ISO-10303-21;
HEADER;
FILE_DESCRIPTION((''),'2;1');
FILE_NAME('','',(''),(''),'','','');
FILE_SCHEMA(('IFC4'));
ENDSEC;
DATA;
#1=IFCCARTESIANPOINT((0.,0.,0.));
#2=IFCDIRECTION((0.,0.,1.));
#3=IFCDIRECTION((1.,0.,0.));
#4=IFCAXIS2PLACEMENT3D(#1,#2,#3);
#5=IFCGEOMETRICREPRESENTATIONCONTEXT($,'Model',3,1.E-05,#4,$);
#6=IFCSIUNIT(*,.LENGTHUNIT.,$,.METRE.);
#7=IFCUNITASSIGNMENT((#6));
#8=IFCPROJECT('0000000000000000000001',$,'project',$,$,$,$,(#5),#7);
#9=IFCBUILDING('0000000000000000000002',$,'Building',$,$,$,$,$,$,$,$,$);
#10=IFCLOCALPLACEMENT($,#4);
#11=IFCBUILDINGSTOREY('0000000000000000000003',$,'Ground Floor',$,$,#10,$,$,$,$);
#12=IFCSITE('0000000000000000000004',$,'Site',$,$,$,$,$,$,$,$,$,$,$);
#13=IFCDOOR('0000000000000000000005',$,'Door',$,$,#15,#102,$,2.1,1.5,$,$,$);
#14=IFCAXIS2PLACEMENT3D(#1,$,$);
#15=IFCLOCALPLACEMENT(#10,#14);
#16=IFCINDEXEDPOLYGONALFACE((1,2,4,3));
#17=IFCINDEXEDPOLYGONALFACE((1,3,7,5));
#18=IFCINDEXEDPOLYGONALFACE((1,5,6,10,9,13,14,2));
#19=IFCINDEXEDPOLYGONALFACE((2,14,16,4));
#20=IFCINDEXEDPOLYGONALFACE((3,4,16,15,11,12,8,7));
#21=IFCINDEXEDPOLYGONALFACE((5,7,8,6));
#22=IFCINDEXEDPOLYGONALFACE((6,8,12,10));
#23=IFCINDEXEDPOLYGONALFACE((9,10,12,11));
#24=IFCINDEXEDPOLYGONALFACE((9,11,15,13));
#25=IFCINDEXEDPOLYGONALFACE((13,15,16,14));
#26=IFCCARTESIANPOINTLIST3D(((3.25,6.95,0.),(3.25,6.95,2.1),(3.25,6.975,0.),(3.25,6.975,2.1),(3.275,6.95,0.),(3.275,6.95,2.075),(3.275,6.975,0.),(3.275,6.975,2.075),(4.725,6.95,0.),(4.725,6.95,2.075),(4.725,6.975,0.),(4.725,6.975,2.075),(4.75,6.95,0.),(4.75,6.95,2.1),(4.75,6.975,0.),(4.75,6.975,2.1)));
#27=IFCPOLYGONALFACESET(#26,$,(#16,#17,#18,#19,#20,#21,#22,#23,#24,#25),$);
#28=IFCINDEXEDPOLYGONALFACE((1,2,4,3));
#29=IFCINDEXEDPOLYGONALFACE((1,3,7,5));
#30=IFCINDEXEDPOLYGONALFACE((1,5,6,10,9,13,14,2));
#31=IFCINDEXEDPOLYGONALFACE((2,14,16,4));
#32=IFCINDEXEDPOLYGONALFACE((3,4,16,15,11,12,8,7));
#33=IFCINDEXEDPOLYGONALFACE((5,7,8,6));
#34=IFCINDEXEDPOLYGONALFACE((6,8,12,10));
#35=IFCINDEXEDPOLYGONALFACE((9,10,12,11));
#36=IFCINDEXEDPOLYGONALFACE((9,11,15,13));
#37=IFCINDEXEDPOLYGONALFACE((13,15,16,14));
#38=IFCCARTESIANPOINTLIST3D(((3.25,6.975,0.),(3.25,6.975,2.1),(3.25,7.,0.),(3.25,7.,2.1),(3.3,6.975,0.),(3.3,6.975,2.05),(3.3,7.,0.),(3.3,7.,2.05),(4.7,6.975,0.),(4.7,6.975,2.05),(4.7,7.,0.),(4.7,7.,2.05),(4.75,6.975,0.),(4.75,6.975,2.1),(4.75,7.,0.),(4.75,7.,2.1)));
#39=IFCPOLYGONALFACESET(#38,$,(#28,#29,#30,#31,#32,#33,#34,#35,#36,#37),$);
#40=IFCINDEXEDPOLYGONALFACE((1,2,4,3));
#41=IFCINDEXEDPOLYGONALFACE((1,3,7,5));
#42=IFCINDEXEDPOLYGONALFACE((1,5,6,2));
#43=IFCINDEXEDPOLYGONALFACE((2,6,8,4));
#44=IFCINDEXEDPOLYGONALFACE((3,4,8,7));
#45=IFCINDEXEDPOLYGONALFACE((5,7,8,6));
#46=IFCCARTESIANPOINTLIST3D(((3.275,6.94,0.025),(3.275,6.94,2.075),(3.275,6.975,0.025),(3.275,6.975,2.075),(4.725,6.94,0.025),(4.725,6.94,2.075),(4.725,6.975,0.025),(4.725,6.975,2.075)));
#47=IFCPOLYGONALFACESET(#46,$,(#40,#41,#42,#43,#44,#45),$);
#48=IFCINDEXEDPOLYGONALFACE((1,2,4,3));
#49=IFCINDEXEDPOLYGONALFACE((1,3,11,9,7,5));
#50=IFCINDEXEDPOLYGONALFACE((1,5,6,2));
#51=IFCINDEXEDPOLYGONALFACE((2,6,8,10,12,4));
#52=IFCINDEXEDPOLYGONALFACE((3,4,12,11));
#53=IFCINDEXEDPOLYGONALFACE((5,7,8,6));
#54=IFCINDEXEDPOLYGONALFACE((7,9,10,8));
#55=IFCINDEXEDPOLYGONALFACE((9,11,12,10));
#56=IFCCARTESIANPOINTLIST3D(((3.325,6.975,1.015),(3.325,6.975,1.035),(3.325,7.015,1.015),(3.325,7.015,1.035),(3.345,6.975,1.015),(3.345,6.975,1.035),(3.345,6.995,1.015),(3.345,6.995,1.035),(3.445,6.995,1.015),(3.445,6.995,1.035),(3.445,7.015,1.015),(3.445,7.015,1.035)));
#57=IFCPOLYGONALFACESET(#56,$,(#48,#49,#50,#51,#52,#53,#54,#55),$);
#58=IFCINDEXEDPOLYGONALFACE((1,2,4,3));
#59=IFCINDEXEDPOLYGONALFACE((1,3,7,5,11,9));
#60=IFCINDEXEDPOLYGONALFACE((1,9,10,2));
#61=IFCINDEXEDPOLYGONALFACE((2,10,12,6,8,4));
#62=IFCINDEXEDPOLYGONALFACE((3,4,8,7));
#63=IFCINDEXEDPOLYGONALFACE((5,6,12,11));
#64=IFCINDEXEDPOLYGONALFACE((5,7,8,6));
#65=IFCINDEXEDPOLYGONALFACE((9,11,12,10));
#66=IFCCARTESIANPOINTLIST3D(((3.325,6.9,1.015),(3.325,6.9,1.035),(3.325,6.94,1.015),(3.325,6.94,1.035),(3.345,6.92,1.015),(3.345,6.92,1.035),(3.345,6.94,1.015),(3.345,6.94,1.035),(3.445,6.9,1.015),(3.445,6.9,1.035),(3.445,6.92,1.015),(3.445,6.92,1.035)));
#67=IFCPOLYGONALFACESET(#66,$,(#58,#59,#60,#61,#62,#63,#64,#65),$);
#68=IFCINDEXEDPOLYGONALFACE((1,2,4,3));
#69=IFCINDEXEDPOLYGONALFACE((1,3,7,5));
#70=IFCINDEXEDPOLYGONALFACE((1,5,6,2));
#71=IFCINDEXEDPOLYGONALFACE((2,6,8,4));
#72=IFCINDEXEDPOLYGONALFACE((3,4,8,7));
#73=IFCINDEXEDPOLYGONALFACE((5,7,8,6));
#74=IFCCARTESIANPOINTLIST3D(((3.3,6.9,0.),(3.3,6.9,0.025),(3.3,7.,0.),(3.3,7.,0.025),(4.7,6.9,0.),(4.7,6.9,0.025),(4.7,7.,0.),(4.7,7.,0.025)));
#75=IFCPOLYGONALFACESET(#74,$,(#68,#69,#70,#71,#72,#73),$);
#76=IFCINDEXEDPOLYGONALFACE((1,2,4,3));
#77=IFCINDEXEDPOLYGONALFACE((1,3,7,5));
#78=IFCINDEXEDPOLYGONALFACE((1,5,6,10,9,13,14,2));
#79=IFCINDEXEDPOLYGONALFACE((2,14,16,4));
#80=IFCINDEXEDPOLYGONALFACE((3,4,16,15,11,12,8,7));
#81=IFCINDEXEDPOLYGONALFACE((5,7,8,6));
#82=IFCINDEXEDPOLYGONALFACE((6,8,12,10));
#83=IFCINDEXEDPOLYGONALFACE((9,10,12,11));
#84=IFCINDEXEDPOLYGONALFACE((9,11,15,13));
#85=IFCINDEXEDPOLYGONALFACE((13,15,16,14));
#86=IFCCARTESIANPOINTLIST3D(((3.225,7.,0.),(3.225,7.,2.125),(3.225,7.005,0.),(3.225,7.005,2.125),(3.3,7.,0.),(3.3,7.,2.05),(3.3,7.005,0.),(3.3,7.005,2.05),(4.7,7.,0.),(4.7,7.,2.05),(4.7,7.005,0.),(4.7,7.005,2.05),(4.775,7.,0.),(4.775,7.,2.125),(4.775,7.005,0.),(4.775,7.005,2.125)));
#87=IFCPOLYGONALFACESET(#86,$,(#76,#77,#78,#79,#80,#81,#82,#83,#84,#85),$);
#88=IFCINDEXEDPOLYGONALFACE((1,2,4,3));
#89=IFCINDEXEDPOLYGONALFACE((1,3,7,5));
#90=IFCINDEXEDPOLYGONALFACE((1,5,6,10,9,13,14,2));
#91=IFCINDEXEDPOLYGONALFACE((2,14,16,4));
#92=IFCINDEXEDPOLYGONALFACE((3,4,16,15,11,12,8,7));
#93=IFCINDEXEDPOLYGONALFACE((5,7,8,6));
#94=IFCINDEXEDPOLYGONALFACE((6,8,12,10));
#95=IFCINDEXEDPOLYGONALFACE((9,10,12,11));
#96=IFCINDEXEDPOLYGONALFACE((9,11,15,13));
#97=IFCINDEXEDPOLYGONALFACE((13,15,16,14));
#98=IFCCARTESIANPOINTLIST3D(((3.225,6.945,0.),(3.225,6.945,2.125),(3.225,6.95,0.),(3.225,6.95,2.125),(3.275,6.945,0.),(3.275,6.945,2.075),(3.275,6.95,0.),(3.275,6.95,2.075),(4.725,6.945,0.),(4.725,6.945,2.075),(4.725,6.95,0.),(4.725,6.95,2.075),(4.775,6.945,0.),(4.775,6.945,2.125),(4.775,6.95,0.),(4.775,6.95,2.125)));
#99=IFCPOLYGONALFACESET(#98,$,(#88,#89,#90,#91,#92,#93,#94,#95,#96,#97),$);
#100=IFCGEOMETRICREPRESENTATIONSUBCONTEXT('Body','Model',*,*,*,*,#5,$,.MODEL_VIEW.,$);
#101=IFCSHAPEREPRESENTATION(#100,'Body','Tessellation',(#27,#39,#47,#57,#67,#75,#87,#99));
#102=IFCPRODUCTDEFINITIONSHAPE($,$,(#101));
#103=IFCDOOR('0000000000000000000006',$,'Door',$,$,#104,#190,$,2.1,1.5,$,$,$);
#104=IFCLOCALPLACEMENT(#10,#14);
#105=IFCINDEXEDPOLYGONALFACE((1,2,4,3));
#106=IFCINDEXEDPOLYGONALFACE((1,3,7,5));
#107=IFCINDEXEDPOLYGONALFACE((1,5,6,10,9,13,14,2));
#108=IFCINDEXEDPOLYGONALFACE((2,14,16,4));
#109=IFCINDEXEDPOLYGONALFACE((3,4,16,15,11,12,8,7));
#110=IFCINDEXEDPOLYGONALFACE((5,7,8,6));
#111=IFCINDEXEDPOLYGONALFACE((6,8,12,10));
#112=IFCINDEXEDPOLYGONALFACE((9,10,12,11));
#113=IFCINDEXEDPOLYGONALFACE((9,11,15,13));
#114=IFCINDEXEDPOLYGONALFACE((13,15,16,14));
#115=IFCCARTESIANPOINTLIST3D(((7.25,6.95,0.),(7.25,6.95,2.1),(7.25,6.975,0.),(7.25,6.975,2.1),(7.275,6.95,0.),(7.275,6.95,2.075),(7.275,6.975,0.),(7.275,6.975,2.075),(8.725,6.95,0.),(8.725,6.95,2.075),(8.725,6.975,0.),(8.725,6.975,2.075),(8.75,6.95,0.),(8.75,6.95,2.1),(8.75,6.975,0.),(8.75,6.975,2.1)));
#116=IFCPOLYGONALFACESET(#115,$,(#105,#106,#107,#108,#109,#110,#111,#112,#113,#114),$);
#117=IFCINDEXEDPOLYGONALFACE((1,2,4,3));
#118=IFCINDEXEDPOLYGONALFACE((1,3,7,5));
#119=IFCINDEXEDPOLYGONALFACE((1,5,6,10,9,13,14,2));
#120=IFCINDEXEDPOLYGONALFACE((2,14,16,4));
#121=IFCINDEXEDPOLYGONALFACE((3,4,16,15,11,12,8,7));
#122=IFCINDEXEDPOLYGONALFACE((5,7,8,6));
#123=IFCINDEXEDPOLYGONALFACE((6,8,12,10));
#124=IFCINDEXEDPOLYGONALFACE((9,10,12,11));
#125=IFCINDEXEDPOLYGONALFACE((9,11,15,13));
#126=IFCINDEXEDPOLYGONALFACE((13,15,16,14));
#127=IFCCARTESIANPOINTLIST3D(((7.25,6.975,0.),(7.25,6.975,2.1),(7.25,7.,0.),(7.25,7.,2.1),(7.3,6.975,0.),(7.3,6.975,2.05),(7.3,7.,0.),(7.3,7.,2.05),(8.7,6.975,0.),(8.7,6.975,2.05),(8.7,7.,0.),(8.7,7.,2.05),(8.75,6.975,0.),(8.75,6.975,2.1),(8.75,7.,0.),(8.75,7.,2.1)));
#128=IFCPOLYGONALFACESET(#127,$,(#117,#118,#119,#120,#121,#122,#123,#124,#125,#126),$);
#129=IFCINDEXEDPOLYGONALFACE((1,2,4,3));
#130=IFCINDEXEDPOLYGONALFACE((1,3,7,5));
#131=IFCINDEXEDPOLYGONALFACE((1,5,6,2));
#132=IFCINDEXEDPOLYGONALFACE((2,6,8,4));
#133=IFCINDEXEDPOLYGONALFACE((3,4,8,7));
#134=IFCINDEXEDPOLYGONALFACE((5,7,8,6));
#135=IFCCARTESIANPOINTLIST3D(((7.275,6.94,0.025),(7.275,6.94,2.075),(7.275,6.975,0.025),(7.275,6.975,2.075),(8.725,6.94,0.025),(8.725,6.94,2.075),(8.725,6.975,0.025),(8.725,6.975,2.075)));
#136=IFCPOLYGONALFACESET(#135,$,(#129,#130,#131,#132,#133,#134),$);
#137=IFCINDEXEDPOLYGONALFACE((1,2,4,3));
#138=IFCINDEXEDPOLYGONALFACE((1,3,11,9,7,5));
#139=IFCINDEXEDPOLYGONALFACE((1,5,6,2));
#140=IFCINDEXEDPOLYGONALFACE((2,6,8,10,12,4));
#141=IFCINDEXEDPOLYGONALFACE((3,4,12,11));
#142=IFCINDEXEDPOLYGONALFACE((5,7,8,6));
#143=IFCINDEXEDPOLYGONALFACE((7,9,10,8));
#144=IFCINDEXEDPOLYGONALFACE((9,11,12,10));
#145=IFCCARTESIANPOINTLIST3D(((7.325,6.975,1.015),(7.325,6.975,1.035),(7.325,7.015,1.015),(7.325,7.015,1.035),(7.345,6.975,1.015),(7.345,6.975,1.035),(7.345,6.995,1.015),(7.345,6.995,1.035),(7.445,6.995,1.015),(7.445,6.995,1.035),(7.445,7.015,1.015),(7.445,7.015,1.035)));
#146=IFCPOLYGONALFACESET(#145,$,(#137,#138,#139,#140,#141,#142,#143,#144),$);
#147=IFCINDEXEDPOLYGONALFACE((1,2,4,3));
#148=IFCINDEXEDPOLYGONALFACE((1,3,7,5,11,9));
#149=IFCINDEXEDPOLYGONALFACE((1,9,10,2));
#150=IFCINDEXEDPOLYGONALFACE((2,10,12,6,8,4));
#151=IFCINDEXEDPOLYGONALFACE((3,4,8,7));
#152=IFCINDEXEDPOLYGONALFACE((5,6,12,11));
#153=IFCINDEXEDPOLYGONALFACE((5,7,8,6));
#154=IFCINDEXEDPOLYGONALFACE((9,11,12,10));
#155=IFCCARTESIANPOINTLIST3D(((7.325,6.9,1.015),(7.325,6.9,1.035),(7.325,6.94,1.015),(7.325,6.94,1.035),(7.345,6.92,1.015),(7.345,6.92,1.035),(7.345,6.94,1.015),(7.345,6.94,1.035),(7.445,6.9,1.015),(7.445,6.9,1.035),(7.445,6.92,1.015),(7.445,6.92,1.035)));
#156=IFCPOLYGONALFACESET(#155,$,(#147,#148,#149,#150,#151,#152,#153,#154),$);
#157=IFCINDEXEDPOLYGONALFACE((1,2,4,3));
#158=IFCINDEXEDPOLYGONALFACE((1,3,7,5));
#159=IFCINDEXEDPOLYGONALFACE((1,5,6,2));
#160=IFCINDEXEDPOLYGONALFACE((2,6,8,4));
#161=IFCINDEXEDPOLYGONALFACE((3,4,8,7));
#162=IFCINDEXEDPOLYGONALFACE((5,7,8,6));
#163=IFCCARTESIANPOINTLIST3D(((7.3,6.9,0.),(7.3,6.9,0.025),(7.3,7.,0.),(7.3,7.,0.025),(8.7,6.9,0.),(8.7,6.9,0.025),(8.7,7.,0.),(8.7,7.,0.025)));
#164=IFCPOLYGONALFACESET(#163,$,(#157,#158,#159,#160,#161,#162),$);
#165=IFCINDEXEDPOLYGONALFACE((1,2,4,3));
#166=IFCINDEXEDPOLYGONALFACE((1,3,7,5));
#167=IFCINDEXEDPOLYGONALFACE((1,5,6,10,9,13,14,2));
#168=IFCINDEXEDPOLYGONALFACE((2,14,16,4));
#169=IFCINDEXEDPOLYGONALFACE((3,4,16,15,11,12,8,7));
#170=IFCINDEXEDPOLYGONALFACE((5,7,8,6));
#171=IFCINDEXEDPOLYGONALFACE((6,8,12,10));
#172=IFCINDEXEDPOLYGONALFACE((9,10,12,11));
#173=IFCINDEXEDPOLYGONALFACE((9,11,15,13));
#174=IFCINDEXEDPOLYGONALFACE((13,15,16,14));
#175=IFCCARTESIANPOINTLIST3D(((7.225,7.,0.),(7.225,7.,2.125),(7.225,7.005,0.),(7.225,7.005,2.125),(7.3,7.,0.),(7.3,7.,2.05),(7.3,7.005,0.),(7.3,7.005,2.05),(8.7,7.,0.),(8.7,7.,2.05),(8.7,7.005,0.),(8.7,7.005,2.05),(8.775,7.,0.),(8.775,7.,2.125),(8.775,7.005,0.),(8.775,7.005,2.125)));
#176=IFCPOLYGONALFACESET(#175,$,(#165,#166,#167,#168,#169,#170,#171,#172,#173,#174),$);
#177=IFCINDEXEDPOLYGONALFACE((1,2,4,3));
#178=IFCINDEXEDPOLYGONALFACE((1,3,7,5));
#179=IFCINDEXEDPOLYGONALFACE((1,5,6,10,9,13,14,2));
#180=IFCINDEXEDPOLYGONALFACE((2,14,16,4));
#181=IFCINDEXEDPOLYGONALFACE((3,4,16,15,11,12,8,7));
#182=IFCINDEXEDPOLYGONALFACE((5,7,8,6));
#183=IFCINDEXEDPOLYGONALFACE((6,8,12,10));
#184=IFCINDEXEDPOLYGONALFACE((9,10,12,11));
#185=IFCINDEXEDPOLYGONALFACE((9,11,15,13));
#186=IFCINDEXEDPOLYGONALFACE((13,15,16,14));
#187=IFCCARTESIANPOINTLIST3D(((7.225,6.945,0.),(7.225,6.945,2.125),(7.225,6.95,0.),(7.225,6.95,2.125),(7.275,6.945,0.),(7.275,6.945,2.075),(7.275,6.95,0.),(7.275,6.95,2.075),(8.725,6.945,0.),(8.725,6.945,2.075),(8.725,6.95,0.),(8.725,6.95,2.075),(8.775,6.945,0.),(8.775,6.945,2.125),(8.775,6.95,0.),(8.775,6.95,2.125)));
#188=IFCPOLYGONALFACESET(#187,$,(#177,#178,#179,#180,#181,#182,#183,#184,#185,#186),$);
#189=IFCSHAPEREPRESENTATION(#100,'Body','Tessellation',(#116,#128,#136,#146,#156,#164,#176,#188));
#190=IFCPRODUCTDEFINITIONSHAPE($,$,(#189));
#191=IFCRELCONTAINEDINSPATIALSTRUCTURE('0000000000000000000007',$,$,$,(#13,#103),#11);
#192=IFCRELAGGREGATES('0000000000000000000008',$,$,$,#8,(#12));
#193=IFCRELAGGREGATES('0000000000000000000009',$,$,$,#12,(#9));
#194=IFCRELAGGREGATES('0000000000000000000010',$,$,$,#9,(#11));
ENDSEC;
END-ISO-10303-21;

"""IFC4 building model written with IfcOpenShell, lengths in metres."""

from ifc_helpers import new_model, si_unit, frame, origin_with_axes, place, context, subcontext, project, spatial, line, indexed_curve, outline, extrude, element, save


model = new_model("IFC4")

# Units and contexts
model_context = context("Model", 3, precision=1e-05, world=origin_with_axes())
body_context = subcontext(model_context, "Body", "Model", "MODEL_VIEW")
ifc_project = project(units=[si_unit("LENGTHUNIT", "METRE")], contexts=[model_context])

# Site, building, storey
site = spatial("IfcSite", under=ifc_project, Name="Site")
building = spatial("IfcBuilding", under=site, Name="Building")
storey_placement = place(None, origin_with_axes())
storey = spatial("IfcBuildingStorey", under=building, at=storey_placement, Name="Ground Floor")

# Doors
door_1_placement = place(storey_placement, frame((4.75, 7.0, 0.0), z_axis=(0.0, 0.0, 1.0), x_axis=(-1.0, 0.0, 0.0)))
element("IfcDoor", 1, at=door_1_placement, inside=storey, Name="Door", OverallHeight=2.1, OverallWidth=1.5, context=body_context, shape_type="SweptSolid", body=[
    extrude(outline(indexed_curve([(0.0, 0.0), (0.0, 2.1), (1.5, 2.1), (1.5, 0.0), (1.475, 0.0), (1.475, 2.075), (0.025, 2.075), (0.025, 0.0)], segments=[line(1, 2, 3, 4, 5, 6, 7, 8, 1)])), frame((0.0, 0.025, 0.0), z_axis=(0.0, -1.0, 0.0), x_axis=(1.0, 0.0, 0.0)), (0.0, 0.0, -1.0), 0.025),
    extrude(outline(indexed_curve([(0.0, 0.0), (0.0, 2.1), (1.5, 2.1), (1.5, 0.0), (1.45, 0.0), (1.45, 2.05), (0.05, 2.05), (0.05, 0.0)], segments=[line(1, 2, 3, 4, 5, 6, 7, 8, 1)])), frame((0.0, 0.0, 0.0), z_axis=(0.0, -1.0, 0.0), x_axis=(1.0, 0.0, 0.0)), (0.0, 0.0, -1.0), 0.025),
    extrude(outline(indexed_curve([(0.0, 0.0), (1.45, 0.0), (1.45, 0.035), (0.0, 0.035)], segments=[line(1, 2, 3, 4, 1)])), frame((0.025, 0.025, 0.025), z_axis=(0.0, 0.0, 1.0), x_axis=(1.0, 0.0, 0.0)), (0.0, 0.0, 1.0), 2.05),
    extrude(outline(indexed_curve([(0.0, 0.0), (0.0, -0.04), (-0.12, -0.04), (-0.12, -0.02), (-0.02, -0.02), (-0.02, 0.0)], segments=[line(1, 2, 3, 4, 5, 6, 1)])), frame((1.425, 0.025, 1.015), z_axis=(0.0, 0.0, 1.0), x_axis=(1.0, 0.0, 0.0)), (0.0, 0.0, 1.0), 0.02),
    extrude(outline(indexed_curve([(0.0, 0.0), (0.0, 0.04), (-0.12, 0.04), (-0.12, 0.02), (-0.02, 0.02), (-0.02, 0.0)], segments=[line(1, 2, 3, 4, 5, 6, 1)])), frame((1.425, 0.06, 1.015), z_axis=(0.0, 0.0, 1.0), x_axis=(1.0, 0.0, 0.0)), (0.0, 0.0, 1.0), 0.02),
    extrude(outline(indexed_curve([(0.0, 0.0), (1.4, 0.0), (1.4, 0.1), (0.0, 0.1)], segments=[line(1, 2, 3, 4, 1)])), frame((0.05, 0.0, 0.0), z_axis=(0.0, 0.0, 1.0), x_axis=(1.0, 0.0, 0.0)), (0.0, 0.0, 1.0), 0.025),
    extrude(outline(indexed_curve([(0.0, 0.0), (0.0, 2.125), (1.55, 2.125), (1.55, 0.0), (1.475, 0.0), (1.475, 2.05), (0.075, 2.05), (0.075, 0.0)], segments=[line(1, 2, 3, 4, 5, 6, 7, 8, 1)])), frame((-0.025, -0.005, 0.0), z_axis=(0.0, -1.0, 0.0), x_axis=(1.0, 0.0, 0.0)), (0.0, 0.0, -1.0), 0.005),
    extrude(outline(indexed_curve([(0.0, 0.0), (0.0, 2.125), (1.55, 2.125), (1.55, 0.0), (1.5, 0.0), (1.5, 2.075), (0.05, 2.075), (0.05, 0.0)], segments=[line(1, 2, 3, 4, 5, 6, 7, 8, 1)])), frame((-0.025, 0.05, 0.0), z_axis=(0.0, -1.0, 0.0), x_axis=(1.0, 0.0, 0.0)), (0.0, 0.0, -1.0), 0.005),
])
door_2_placement = place(storey_placement, frame((8.75, 7.0, 0.0), z_axis=(0.0, 0.0, 1.0), x_axis=(-1.0, 0.0, 0.0)))
element("IfcDoor", 2, at=door_2_placement, inside=storey, Name="Door", OverallHeight=2.1, OverallWidth=1.5, context=body_context, shape_type="SweptSolid", body=[
    extrude(outline(indexed_curve([(0.0, 0.0), (0.0, 2.1), (1.5, 2.1), (1.5, 0.0), (1.475, 0.0), (1.475, 2.075), (0.025, 2.075), (0.025, 0.0)], segments=[line(1, 2, 3, 4, 5, 6, 7, 8, 1)])), frame((0.0, 0.025, 0.0), z_axis=(0.0, -1.0, 0.0), x_axis=(1.0, 0.0, 0.0)), (0.0, 0.0, -1.0), 0.025),
    extrude(outline(indexed_curve([(0.0, 0.0), (0.0, 2.1), (1.5, 2.1), (1.5, 0.0), (1.45, 0.0), (1.45, 2.05), (0.05, 2.05), (0.05, 0.0)], segments=[line(1, 2, 3, 4, 5, 6, 7, 8, 1)])), frame((0.0, 0.0, 0.0), z_axis=(0.0, -1.0, 0.0), x_axis=(1.0, 0.0, 0.0)), (0.0, 0.0, -1.0), 0.025),
    extrude(outline(indexed_curve([(0.0, 0.0), (1.45, 0.0), (1.45, 0.035), (0.0, 0.035)], segments=[line(1, 2, 3, 4, 1)])), frame((0.025, 0.025, 0.025), z_axis=(0.0, 0.0, 1.0), x_axis=(1.0, 0.0, 0.0)), (0.0, 0.0, 1.0), 2.05),
    extrude(outline(indexed_curve([(0.0, 0.0), (0.0, -0.04), (-0.12, -0.04), (-0.12, -0.02), (-0.02, -0.02), (-0.02, 0.0)], segments=[line(1, 2, 3, 4, 5, 6, 1)])), frame((1.425, 0.025, 1.015), z_axis=(0.0, 0.0, 1.0), x_axis=(1.0, 0.0, 0.0)), (0.0, 0.0, 1.0), 0.02),
    extrude(outline(indexed_curve([(0.0, 0.0), (0.0, 0.04), (-0.12, 0.04), (-0.12, 0.02), (-0.02, 0.02), (-0.02, 0.0)], segments=[line(1, 2, 3, 4, 5, 6, 1)])), frame((1.425, 0.06, 1.015), z_axis=(0.0, 0.0, 1.0), x_axis=(1.0, 0.0, 0.0)), (0.0, 0.0, 1.0), 0.02),
    extrude(outline(indexed_curve([(0.0, 0.0), (1.4, 0.0), (1.4, 0.1), (0.0, 0.1)], segments=[line(1, 2, 3, 4, 1)])), frame((0.05, 0.0, 0.0), z_axis=(0.0, 0.0, 1.0), x_axis=(1.0, 0.0, 0.0)), (0.0, 0.0, 1.0), 0.025),
    extrude(outline(indexed_curve([(0.0, 0.0), (0.0, 2.125), (1.55, 2.125), (1.55, 0.0), (1.475, 0.0), (1.475, 2.05), (0.075, 2.05), (0.075, 0.0)], segments=[line(1, 2, 3, 4, 5, 6, 7, 8, 1)])), frame((-0.025, -0.005, 0.0), z_axis=(0.0, -1.0, 0.0), x_axis=(1.0, 0.0, 0.0)), (0.0, 0.0, -1.0), 0.005),
    extrude(outline(indexed_curve([(0.0, 0.0), (0.0, 2.125), (1.55, 2.125), (1.55, 0.0), (1.5, 0.0), (1.5, 2.075), (0.05, 2.075), (0.05, 0.0)], segments=[line(1, 2, 3, 4, 5, 6, 7, 8, 1)])), frame((-0.025, 0.05, 0.0), z_axis=(0.0, -1.0, 0.0), x_axis=(1.0, 0.0, 0.0)), (0.0, 0.0, -1.0), 0.005),
])

save(model, "model.ifc")
